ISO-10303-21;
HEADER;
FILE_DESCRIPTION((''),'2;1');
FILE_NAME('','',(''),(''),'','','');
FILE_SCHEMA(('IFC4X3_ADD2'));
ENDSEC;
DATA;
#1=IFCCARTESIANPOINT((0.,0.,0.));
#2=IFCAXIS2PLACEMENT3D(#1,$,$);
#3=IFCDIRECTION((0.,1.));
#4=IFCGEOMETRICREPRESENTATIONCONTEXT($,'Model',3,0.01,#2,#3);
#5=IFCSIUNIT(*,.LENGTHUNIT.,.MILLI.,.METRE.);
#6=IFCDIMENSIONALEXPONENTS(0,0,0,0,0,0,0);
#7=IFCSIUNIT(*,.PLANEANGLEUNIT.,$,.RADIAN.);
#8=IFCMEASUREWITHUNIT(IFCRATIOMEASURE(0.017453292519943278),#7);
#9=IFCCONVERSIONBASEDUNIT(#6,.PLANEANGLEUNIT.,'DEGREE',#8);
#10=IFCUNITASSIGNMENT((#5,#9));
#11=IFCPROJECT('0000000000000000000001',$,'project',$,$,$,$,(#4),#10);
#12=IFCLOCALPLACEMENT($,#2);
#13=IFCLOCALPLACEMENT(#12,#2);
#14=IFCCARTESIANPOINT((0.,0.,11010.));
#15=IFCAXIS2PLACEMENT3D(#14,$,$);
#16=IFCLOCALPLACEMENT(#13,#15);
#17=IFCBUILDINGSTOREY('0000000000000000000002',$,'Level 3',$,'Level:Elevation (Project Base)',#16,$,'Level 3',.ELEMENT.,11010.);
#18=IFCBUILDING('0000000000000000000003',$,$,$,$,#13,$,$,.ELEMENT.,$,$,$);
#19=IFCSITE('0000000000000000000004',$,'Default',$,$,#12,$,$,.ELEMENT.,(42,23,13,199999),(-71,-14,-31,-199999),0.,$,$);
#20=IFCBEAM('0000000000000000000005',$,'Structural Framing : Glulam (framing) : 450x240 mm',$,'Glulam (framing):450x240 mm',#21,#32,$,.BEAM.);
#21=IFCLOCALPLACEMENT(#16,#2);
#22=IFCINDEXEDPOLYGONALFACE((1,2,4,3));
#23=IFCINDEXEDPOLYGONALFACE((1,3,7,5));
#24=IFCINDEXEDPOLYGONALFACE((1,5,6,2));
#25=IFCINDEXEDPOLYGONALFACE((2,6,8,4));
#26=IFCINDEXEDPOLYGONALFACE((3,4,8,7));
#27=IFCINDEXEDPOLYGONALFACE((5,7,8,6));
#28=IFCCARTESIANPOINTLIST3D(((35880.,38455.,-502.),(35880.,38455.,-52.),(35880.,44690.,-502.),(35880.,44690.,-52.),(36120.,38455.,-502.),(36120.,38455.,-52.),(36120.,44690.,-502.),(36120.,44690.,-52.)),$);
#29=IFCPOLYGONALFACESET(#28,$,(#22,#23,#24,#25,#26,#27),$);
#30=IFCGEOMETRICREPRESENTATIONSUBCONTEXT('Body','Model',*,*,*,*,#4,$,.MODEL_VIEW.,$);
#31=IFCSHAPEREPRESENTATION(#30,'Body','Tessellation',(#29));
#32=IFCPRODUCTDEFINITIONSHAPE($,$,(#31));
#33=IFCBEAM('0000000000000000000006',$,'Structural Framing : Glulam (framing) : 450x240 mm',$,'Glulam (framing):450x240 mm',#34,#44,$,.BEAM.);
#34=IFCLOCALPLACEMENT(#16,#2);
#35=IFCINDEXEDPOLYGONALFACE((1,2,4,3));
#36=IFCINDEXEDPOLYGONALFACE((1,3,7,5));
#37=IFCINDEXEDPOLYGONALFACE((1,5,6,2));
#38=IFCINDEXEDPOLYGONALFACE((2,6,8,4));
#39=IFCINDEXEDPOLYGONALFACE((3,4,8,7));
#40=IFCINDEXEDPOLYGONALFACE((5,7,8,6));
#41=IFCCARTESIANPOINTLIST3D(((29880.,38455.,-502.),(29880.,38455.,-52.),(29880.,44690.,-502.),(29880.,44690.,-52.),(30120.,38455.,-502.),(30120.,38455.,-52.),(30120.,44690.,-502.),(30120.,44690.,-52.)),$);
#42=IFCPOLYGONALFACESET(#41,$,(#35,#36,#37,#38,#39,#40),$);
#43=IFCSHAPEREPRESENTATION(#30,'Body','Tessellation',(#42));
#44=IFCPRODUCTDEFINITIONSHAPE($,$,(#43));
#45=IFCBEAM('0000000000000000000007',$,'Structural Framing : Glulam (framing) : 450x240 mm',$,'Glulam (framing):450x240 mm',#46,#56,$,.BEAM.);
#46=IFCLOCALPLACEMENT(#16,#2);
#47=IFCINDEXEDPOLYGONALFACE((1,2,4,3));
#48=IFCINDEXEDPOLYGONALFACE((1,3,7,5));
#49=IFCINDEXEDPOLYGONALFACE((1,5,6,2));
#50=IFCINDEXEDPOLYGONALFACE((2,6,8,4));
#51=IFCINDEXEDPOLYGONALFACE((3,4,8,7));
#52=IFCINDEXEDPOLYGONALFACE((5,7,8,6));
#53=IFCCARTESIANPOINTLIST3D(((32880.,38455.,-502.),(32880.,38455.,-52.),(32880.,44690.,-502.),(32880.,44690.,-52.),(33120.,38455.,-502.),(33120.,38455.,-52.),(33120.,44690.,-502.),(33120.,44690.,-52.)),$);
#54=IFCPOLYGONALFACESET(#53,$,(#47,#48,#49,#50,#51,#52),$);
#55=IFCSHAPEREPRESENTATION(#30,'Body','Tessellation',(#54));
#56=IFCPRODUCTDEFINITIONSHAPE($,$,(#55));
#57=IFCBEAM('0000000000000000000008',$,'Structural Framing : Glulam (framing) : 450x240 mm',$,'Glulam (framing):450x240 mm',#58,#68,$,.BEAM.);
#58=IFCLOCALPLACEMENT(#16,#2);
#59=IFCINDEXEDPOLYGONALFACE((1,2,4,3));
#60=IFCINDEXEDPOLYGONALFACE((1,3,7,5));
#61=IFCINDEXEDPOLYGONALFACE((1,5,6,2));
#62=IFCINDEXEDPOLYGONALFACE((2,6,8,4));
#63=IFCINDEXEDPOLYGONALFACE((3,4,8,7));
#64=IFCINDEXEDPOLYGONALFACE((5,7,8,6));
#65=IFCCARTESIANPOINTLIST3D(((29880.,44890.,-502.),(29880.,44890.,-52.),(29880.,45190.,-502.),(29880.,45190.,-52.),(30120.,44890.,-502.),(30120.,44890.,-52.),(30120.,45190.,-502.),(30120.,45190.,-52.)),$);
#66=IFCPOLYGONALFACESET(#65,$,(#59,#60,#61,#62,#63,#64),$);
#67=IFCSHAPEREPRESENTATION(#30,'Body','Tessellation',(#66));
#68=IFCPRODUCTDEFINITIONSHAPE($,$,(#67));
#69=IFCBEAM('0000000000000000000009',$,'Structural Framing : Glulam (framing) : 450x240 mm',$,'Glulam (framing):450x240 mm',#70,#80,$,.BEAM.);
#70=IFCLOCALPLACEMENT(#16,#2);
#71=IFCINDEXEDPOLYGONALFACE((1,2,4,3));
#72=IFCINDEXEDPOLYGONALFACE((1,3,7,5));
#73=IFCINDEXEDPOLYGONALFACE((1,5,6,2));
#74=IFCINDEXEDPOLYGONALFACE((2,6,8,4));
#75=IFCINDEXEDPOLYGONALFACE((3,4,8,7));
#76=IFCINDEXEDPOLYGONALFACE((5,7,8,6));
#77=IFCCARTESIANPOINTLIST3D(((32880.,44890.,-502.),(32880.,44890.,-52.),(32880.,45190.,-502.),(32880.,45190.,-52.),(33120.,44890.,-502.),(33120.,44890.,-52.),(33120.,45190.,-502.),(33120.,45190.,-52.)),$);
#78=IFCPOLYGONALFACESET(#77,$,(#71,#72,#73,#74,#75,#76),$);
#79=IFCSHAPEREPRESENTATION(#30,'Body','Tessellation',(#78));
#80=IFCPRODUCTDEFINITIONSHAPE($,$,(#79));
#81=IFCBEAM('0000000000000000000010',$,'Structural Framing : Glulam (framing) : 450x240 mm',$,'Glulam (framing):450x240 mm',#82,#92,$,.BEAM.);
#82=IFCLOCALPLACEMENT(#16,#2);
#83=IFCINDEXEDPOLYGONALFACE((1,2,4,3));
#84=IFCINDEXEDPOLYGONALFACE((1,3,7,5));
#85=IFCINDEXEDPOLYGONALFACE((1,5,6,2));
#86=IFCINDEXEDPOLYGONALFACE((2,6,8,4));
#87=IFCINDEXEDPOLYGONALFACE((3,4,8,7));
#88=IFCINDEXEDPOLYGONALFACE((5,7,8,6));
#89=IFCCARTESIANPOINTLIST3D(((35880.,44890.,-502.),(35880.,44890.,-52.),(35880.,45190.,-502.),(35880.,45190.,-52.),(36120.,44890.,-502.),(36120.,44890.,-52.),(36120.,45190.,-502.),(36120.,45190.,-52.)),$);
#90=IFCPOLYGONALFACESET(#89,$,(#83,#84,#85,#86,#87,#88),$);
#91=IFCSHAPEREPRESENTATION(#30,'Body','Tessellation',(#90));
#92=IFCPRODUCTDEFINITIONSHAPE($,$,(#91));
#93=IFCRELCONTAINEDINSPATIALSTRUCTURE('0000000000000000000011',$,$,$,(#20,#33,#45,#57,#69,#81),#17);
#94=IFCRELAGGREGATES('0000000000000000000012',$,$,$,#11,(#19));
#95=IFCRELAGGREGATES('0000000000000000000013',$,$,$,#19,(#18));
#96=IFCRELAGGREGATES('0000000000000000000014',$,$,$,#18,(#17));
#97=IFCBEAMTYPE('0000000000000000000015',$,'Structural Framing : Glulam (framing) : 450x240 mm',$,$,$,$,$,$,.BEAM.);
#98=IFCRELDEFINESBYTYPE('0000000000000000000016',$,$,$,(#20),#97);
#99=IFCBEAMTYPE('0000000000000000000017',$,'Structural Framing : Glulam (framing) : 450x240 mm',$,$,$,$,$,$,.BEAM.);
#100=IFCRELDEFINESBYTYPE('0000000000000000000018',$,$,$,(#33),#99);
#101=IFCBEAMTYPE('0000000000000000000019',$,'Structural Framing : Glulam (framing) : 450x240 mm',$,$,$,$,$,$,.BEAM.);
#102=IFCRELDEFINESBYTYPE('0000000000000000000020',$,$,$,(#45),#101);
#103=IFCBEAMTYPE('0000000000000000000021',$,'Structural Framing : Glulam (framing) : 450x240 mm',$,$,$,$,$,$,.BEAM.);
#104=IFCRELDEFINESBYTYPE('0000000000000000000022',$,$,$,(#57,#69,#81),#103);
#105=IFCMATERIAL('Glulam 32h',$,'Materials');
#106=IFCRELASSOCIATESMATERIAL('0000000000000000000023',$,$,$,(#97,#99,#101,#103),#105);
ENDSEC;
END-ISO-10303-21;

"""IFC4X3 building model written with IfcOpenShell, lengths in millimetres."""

from ifc_helpers import new_model, entity, si_unit, converted_unit, direction, frame, origin, origin_2d_with_axis, place, context, subcontext, project, spatial, rectangle, extrude, source, transform, mapped, material, material_profile, profile_set, type_object, type_shapes, element, save


model = new_model("IFC4X3")

# Units and contexts
model_context = context("Model", 3, precision=0.01, world=origin(), true_north=direction((0.0, 1.0)))
body_context = subcontext(model_context, "Body", "Model", "MODEL_VIEW")
ifc_project = project(units=[si_unit("LENGTHUNIT", "METRE", prefix="MILLI"), converted_unit("PLANEANGLEUNIT", "DEGREE", entity("IfcRatioMeasure", 0.017453292519943278), si_unit("PLANEANGLEUNIT", "RADIAN"), dimensions=[0, 0, 0, 0, 0, 0, 0])], contexts=[model_context])

# Site, building, storey
site_placement = place(None, origin())
site = spatial("IfcSite", under=ifc_project, at=site_placement, Name="Default", CompositionType="ELEMENT", RefLatitude=(42, 23, 13, 199999), RefLongitude=(-71, -14, -31, -199999), RefElevation=0.0)
building_placement = place(site_placement, origin())
building = spatial("IfcBuilding", under=site, at=building_placement, CompositionType="ELEMENT")
storey_placement = place(building_placement, frame((0.0, 0.0, 11010.0)))
storey = spatial("IfcBuildingStorey", under=building, at=storey_placement, Name="Level 3", ObjectType="Level:Elevation (Project Base)", LongName="Level 3", CompositionType="ELEMENT", Elevation=11010.0)

# Beams
ifc_material_1 = material(Name="Glulam 32h", Category="Materials")
ifc_material_profile_1 = material_profile(ifc_material_1, rectangle(XDim=450.0, YDim=240.0, at=origin_2d_with_axis()), Name="450x240 mm")
ifc_profile_set_1 = profile_set([ifc_material_profile_1], Name="450x240 mm")
beam_type_1 = type_object("IfcBeamType", Name="Structural Framing : Glulam (framing) : 450x240 mm", PredefinedType="BEAM", material=ifc_profile_set_1)
shared_shape_1 = source(origin(), body_context, "Body", "SweptSolid", [
    extrude(rectangle(XDim=450.0, YDim=240.0, at=origin_2d_with_axis()), frame((-2940.0, 0.0, 0.0), z_axis=(1.0, 0.0, 0.0), x_axis=(0.0, 0.0, -1.0)), (0.0, 0.0, 1.0), 6235.0),
])
type_shapes(beam_type_1, [shared_shape_1])
beam_1_placement = place(storey_placement, frame((36000.0, 41750.0, -277.0), z_axis=(0.0, 0.0, 1.0), x_axis=(0.0, -1.0, 0.0)))
element("IfcBeam", 1, at=beam_1_placement, inside=storey, type_object=beam_type_1, Name="Structural Framing : Glulam (framing) : 450x240 mm", ObjectType="Glulam (framing):450x240 mm", PredefinedType="BEAM", context=body_context, shape_type="MappedRepresentation", body=[
    mapped(shared_shape_1, transform((0.0, 0.0, 0.0), scale=1.0)),
])
beam_type_2 = type_object("IfcBeamType", Name="Structural Framing : Glulam (framing) : 450x240 mm", PredefinedType="BEAM", material=ifc_profile_set_1)
shared_shape_2 = source(origin(), body_context, "Body", "SweptSolid", [
    extrude(rectangle(XDim=450.0, YDim=240.0, at=origin_2d_with_axis()), frame((-2920.0, 0.0, 0.0), z_axis=(1.0, 0.0, 0.0), x_axis=(0.0, 0.0, -1.0)), (0.0, 0.0, 1.0), 6235.0),
])
type_shapes(beam_type_2, [shared_shape_2])
beam_2_placement = place(storey_placement, frame((30000.0, 41770.0, -277.0), z_axis=(0.0, 0.0, 1.0), x_axis=(0.0, -1.0, 0.0)))
element("IfcBeam", 2, at=beam_2_placement, inside=storey, type_object=beam_type_2, Name="Structural Framing : Glulam (framing) : 450x240 mm", ObjectType="Glulam (framing):450x240 mm", PredefinedType="BEAM", context=body_context, shape_type="MappedRepresentation", body=[
    mapped(shared_shape_2, transform((0.0, 0.0, 0.0), scale=1.0)),
])
beam_type_3 = type_object("IfcBeamType", Name="Structural Framing : Glulam (framing) : 450x240 mm", PredefinedType="BEAM", material=ifc_profile_set_1)
shared_shape_3 = source(origin(), body_context, "Body", "SweptSolid", [
    extrude(rectangle(XDim=450.0, YDim=240.0, at=origin_2d_with_axis()), frame((-2930.0, 0.0, 0.0), z_axis=(1.0, 0.0, 0.0), x_axis=(0.0, 0.0, -1.0)), (0.0, 0.0, 1.0), 6235.0),
])
type_shapes(beam_type_3, [shared_shape_3])
beam_3_placement = place(storey_placement, frame((33000.0, 41760.0, -277.0), z_axis=(0.0, 0.0, 1.0), x_axis=(0.0, -1.0, 0.0)))
element("IfcBeam", 3, at=beam_3_placement, inside=storey, type_object=beam_type_3, Name="Structural Framing : Glulam (framing) : 450x240 mm", ObjectType="Glulam (framing):450x240 mm", PredefinedType="BEAM", context=body_context, shape_type="MappedRepresentation", body=[
    mapped(shared_shape_3, transform((0.0, 0.0, 0.0), scale=1.0)),
])
beam_type_4 = type_object("IfcBeamType", Name="Structural Framing : Glulam (framing) : 450x240 mm", PredefinedType="BEAM", material=ifc_profile_set_1)
shared_shape_4 = source(origin(), body_context, "Body", "SweptSolid", [
    extrude(rectangle(XDim=450.0, YDim=240.0, at=origin_2d_with_axis()), frame((5043.7, 0.0, 0.0), z_axis=(1.0, 0.0, 0.0), x_axis=(0.0, 0.0, -1.0)), (0.0, 0.0, 1.0), 300.0),
])
type_shapes(beam_type_4, [shared_shape_4])
for number, where, z_axis, x_axis, name in (
    (4, (30000.0, 50233.7, -277.0), (0.0, 0.0, 1.0), (0.0, -1.0, 0.0), "Structural Framing : Glulam (framing) : 450x240 mm"),
    (5, (33000.0, 50233.7, -277.0), (0.0, 0.0, 1.0), (0.0, -1.0, 0.0), "Structural Framing : Glulam (framing) : 450x240 mm"),
    (6, (36000.0, 50233.7, -277.0), (0.0, 0.0, 1.0), (0.0, -1.0, 0.0), "Structural Framing : Glulam (framing) : 450x240 mm"),
):
    element("IfcBeam", number, at=place(storey_placement, frame(where, z_axis=z_axis, x_axis=x_axis)), inside=storey, type_object=beam_type_4, Name=name, ObjectType="Glulam (framing):450x240 mm", PredefinedType="BEAM", context=body_context, shape_type="MappedRepresentation", body=[
        mapped(shared_shape_4, transform((0.0, 0.0, 0.0), scale=1.0)),
    ])

save(model, "model.ifc")
